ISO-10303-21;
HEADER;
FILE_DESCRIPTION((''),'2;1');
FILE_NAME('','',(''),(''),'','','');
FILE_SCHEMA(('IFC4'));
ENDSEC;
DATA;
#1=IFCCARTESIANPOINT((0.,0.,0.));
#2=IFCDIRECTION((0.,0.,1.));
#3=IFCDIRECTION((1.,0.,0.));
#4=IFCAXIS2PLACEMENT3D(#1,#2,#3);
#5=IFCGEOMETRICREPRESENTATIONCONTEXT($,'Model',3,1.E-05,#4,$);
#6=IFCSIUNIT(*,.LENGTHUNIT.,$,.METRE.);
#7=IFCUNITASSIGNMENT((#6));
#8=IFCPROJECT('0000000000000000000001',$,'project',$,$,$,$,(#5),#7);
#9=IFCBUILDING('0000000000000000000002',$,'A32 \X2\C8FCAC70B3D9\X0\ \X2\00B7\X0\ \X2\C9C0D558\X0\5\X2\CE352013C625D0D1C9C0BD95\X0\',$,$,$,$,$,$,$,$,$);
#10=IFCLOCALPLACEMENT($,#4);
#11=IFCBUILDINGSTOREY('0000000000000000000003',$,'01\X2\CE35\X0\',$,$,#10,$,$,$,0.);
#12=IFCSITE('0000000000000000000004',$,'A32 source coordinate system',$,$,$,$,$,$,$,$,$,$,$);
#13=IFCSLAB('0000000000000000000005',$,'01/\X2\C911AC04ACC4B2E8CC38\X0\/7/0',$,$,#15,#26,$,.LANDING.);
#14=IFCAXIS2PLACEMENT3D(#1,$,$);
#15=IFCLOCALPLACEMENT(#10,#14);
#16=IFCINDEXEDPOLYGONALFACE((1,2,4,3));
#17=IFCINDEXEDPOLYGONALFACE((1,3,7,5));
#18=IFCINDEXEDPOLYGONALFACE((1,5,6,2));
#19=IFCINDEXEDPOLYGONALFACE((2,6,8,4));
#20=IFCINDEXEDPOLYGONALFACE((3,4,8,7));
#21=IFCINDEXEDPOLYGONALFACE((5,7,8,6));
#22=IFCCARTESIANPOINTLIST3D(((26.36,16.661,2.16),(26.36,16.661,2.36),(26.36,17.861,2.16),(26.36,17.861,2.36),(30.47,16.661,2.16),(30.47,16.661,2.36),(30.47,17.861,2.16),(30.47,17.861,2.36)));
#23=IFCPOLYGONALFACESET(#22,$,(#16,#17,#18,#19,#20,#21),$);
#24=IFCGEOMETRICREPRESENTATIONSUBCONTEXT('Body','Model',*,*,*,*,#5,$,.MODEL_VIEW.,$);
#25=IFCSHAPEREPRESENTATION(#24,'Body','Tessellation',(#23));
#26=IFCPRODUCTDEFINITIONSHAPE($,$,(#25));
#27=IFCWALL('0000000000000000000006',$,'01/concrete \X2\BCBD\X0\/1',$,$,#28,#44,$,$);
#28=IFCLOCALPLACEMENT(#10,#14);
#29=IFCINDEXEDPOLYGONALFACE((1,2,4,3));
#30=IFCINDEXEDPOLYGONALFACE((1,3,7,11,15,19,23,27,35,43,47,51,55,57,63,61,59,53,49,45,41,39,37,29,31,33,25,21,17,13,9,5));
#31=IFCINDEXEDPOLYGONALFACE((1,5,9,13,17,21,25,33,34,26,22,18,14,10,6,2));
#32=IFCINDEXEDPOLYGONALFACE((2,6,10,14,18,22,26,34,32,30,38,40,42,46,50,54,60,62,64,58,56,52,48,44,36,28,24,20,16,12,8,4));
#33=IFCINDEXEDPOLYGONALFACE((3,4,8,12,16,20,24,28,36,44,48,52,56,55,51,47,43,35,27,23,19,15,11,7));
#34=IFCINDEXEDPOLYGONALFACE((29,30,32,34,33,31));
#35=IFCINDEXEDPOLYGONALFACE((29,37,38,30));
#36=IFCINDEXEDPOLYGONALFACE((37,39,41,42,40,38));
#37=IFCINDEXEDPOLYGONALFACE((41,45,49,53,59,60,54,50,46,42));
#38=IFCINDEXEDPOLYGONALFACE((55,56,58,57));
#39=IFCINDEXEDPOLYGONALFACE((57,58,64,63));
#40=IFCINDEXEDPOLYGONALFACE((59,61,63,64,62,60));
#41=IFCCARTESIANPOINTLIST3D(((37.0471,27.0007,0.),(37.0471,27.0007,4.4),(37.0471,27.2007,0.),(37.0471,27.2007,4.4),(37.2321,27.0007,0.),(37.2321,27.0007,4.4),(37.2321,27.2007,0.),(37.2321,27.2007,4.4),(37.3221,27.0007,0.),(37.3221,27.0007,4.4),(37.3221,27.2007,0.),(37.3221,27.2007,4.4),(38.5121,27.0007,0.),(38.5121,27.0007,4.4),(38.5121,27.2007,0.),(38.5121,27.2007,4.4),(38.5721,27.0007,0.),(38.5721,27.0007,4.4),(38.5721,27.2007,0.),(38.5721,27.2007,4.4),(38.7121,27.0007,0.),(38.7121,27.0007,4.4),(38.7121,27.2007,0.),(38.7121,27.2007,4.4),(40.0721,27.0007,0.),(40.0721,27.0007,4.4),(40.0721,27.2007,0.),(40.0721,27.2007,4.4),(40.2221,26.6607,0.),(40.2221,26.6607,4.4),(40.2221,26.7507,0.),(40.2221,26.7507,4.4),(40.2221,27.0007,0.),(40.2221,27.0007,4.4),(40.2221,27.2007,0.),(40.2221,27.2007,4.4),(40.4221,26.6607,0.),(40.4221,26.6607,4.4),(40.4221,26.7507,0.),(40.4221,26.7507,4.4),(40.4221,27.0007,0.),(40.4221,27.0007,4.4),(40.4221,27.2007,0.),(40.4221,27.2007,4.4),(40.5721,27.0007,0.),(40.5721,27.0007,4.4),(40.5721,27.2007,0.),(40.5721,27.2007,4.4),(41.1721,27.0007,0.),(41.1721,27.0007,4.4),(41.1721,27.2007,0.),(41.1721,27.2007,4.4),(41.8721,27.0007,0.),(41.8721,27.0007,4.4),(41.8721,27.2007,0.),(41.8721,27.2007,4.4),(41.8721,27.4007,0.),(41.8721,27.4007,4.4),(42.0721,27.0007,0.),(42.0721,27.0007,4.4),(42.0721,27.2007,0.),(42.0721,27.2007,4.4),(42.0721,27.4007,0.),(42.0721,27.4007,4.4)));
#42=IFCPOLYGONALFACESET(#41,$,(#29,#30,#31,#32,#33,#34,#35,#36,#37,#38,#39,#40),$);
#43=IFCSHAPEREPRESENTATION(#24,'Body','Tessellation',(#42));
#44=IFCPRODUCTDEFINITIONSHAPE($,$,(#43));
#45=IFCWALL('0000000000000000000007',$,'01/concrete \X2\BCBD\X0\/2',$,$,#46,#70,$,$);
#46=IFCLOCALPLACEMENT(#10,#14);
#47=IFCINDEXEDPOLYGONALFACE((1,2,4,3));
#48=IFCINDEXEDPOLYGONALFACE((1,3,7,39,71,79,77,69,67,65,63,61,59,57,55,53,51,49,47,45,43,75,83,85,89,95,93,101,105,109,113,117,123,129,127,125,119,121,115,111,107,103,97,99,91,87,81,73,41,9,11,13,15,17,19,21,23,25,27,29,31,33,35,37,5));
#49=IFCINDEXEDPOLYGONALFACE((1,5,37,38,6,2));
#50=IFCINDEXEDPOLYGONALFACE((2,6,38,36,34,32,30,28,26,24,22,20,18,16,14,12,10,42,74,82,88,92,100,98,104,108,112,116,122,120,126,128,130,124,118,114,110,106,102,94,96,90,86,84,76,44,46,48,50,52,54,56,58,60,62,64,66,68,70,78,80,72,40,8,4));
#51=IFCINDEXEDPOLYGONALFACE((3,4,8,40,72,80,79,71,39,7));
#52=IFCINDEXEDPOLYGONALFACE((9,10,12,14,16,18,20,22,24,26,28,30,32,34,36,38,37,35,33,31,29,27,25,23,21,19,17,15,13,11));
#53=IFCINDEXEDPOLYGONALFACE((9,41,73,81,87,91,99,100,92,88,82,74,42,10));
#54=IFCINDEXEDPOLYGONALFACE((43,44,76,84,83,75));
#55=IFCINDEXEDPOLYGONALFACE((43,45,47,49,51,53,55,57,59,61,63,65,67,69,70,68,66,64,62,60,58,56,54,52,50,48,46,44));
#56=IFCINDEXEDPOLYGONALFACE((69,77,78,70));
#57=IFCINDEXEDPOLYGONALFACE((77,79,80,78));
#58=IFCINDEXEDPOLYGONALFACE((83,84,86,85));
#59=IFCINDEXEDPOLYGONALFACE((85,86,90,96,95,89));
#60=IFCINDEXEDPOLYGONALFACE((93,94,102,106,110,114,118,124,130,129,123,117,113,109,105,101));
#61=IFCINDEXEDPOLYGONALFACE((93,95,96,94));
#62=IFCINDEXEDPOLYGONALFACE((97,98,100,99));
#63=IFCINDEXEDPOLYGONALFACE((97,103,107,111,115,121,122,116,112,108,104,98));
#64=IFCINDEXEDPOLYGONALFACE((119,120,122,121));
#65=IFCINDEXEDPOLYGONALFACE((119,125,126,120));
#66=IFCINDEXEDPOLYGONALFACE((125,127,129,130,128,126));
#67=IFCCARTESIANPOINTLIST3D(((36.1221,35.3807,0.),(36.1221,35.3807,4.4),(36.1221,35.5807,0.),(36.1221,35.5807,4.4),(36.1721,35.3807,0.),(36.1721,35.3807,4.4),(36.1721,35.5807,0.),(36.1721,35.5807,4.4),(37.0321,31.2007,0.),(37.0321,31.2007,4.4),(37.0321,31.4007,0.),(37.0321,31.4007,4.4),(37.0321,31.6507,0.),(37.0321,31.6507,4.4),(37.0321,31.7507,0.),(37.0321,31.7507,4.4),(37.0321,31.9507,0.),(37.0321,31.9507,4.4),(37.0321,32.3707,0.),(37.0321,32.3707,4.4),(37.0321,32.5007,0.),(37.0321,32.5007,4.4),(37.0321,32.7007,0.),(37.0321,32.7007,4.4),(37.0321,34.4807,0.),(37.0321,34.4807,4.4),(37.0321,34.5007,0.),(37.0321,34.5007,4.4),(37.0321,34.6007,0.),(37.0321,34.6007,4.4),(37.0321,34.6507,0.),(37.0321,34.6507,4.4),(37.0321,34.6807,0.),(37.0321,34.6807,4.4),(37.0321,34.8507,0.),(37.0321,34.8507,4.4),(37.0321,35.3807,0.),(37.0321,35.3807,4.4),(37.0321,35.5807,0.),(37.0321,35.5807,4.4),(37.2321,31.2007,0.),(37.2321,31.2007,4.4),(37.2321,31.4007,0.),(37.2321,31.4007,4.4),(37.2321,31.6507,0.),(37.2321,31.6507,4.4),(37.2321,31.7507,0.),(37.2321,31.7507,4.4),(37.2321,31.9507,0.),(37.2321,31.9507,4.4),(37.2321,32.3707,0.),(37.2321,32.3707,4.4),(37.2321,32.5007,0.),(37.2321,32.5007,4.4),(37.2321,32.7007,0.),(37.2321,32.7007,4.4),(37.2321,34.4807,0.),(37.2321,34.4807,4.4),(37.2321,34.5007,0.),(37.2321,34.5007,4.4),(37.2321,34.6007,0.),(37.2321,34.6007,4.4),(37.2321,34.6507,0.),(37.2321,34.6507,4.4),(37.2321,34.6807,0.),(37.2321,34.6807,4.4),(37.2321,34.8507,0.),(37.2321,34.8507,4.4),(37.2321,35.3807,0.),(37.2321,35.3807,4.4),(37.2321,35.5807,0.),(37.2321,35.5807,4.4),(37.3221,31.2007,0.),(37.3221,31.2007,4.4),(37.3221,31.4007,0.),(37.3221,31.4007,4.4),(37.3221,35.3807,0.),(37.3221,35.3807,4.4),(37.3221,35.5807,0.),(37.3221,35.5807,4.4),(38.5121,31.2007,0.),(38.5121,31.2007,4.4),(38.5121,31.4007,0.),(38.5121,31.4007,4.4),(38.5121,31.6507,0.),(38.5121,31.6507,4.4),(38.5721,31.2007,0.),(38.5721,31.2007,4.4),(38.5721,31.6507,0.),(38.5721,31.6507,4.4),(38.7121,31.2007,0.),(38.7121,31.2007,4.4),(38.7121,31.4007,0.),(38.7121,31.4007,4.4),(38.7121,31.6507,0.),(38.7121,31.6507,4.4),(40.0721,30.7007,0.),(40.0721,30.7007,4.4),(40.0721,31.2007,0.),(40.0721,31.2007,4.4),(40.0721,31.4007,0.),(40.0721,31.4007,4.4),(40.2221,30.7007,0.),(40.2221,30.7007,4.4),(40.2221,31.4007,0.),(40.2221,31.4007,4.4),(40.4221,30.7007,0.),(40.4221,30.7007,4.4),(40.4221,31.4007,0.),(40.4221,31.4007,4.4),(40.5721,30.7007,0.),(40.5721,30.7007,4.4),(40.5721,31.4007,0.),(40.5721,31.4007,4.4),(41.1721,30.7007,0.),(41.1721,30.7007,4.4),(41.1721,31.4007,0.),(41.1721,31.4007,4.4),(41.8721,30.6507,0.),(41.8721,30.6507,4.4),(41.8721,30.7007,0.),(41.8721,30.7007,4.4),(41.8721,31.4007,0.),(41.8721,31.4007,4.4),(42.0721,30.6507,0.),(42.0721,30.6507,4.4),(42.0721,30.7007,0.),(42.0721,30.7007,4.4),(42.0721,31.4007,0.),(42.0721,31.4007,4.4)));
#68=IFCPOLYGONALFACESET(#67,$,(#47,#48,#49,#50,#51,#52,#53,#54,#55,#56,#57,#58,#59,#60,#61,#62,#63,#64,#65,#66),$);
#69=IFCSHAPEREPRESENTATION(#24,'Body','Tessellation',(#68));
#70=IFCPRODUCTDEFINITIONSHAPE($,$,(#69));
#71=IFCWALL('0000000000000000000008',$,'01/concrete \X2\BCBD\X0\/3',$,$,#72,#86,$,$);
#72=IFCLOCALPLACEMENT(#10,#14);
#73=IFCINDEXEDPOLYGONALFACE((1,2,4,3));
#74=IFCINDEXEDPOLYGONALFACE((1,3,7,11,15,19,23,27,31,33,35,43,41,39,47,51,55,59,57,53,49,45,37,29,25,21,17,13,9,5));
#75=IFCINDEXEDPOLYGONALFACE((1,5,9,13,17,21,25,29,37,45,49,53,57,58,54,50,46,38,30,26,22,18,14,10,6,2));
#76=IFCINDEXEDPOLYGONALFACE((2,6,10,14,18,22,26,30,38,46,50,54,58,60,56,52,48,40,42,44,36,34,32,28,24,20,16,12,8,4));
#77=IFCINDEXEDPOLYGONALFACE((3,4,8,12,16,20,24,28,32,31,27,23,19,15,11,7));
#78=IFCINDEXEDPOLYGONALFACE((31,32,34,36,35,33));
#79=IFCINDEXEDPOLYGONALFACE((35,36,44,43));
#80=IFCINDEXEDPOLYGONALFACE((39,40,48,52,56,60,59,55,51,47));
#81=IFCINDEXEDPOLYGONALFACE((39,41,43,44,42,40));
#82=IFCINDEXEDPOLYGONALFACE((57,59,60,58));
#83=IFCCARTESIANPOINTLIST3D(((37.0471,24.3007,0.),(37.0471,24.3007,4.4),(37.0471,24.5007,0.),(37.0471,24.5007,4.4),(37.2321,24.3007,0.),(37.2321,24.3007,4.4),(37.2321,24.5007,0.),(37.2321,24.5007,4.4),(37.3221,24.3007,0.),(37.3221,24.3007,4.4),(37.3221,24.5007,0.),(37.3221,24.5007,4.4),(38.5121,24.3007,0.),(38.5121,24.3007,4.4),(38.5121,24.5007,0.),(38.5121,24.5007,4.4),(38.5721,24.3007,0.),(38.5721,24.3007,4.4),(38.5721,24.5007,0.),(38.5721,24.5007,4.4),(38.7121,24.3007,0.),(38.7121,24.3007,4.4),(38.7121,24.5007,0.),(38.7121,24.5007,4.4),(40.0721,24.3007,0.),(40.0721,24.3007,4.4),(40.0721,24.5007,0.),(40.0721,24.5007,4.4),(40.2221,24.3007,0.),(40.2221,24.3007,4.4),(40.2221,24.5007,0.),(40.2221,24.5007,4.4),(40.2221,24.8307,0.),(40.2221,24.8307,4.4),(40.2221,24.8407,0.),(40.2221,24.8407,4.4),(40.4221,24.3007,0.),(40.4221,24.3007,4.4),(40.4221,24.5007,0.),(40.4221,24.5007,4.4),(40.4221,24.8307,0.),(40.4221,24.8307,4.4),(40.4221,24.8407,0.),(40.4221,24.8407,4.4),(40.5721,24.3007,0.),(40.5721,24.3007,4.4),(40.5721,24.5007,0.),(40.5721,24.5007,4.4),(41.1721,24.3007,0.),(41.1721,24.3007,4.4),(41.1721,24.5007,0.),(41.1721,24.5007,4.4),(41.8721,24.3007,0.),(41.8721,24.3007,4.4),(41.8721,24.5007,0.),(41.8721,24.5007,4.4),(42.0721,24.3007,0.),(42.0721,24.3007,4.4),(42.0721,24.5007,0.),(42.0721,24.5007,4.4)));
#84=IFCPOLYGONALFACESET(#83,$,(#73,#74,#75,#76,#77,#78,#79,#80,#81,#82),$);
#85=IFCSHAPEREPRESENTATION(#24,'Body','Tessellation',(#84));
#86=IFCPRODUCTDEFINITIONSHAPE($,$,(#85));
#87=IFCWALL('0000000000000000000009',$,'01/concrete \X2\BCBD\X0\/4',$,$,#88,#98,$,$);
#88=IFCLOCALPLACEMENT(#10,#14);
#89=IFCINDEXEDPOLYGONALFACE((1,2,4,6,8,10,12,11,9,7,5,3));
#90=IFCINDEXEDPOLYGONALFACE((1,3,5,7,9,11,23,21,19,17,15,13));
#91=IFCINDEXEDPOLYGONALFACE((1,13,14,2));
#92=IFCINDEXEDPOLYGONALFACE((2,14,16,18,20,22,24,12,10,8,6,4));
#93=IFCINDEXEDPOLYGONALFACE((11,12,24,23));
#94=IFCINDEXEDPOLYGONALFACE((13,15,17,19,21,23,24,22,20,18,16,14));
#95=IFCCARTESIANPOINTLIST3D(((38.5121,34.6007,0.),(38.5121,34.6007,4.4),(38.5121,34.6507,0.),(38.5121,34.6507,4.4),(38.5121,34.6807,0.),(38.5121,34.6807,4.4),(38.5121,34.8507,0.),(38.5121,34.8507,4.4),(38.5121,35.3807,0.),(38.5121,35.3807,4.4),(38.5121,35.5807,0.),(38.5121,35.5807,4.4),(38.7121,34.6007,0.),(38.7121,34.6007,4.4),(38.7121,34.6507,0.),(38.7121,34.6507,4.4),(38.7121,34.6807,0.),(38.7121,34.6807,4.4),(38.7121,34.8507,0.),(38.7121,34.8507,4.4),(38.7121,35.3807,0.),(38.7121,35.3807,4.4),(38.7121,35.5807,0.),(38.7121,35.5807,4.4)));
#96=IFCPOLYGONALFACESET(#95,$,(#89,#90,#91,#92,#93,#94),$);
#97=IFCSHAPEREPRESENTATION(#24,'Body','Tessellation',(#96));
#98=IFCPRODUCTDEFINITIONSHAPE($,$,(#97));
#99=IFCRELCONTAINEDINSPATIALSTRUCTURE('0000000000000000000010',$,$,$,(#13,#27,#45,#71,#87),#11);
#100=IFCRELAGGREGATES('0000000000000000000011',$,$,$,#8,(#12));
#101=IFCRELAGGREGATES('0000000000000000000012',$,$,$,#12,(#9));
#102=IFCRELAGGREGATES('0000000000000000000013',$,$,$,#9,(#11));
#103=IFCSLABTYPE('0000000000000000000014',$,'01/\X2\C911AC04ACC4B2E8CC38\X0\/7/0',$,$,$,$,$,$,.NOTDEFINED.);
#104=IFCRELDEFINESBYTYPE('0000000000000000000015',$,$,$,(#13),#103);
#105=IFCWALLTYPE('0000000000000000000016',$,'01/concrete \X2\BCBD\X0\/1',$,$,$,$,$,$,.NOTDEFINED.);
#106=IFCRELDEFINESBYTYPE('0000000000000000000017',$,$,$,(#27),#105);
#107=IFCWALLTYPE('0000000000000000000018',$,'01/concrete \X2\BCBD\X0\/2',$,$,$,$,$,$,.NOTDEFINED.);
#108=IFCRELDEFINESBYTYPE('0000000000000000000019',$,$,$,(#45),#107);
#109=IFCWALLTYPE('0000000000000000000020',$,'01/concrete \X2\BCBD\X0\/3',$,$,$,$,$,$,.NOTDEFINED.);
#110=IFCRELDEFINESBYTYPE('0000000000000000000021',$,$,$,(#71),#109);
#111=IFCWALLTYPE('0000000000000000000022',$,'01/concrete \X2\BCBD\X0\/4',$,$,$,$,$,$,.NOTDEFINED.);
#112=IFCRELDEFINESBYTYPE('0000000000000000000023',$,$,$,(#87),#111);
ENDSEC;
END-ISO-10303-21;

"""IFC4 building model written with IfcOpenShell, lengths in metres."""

from ifc_helpers import new_model, si_unit, frame, origin, origin_with_axes, place, context, subcontext, project, spatial, polyline, outline, extrude, source, transform, mapped, type_object, type_shapes, element, save


model = new_model("IFC4")

# Units and contexts
model_context = context("Model", 3, precision=1e-05, world=origin_with_axes())
body_context = subcontext(model_context, "Body", "Model", "MODEL_VIEW")
ifc_project = project(units=[si_unit("LENGTHUNIT", "METRE")], contexts=[model_context])

# Site, building, storey
storey_placement = place(None, origin_with_axes())
site = spatial("IfcSite", under=ifc_project, Name="A32 source coordinate system")
building = spatial("IfcBuilding", under=site, Name="A32 주거동 · 지하5층–옥탑지붕")
storey = spatial("IfcBuildingStorey", under=building, at=storey_placement, Name="01층", Elevation=0.0)

# Slab
slab_type_1 = type_object("IfcSlabType", Name="01/중간계단참/7/0", PredefinedType="NOTDEFINED")
shared_shape_1 = source(origin(), body_context, "Body", "SweptSolid", [
    extrude(outline(polyline([(30.47, 16.661), (26.36, 16.661), (26.36, 17.861), (30.47, 17.861), (30.47, 16.661)])), frame((0.0, 0.0, 2.16)), (0.0, 0.0, 1.0), 0.2),
])
type_shapes(slab_type_1, [shared_shape_1])
slab_1_placement = place(storey_placement, origin_with_axes())
element("IfcSlab", 1, at=slab_1_placement, inside=storey, type_object=slab_type_1, Name="01/중간계단참/7/0", PredefinedType="LANDING", context=body_context, shape_type="MappedRepresentation", body=[
    mapped(shared_shape_1, transform((0.0, 0.0, 0.0), scale=1.0)),
])

# Walls
wall_type_1 = type_object("IfcWallType", Name="01/concrete 벽/1", PredefinedType="NOTDEFINED")
shared_shape_2 = source(origin(), body_context, "Body", "SweptSolid", [
    extrude(outline(polyline([(37.3221, 27.2007), (38.5121, 27.2007), (38.5721, 27.2007), (38.7121, 27.2007), (40.0721, 27.2007), (40.2221, 27.2007), (40.4221, 27.2007), (40.5721, 27.2007), (41.1721, 27.2007), (41.8721, 27.2007), (41.8721, 27.4007), (42.0721, 27.4007), (42.0721, 27.2007), (42.0721, 27.0007), (41.8721, 27.0007), (41.1721, 27.0007), (40.5721, 27.0007), (40.4221, 27.0007), (40.4221, 26.7507), (40.4221, 26.6607), (40.2221, 26.6607), (40.2221, 26.7507), (40.2221, 27.0007), (40.0721, 27.0007), (38.7121, 27.0007), (38.5721, 27.0007), (38.5121, 27.0007), (37.3221, 27.0007), (37.2321, 27.0007), (37.0471, 27.0007), (37.0471, 27.2007), (37.2321, 27.2007), (37.3221, 27.2007)])), origin(), (0.0, 0.0, 1.0), 4.4),
])
type_shapes(wall_type_1, [shared_shape_2])
wall_1_placement = place(storey_placement, origin_with_axes())
element("IfcWall", 2, at=wall_1_placement, inside=storey, type_object=wall_type_1, Name="01/concrete 벽/1", context=body_context, shape_type="MappedRepresentation", body=[
    mapped(shared_shape_2, transform((0.0, 0.0, 0.0), scale=1.0)),
])
wall_type_2 = type_object("IfcWallType", Name="01/concrete 벽/2", PredefinedType="NOTDEFINED")
shared_shape_3 = source(origin(), body_context, "Body", "SweptSolid", [
    extrude(outline(polyline([(38.7121, 31.4007), (40.0721, 31.4007), (40.2221, 31.4007), (40.4221, 31.4007), (40.5721, 31.4007), (41.1721, 31.4007), (41.8721, 31.4007), (42.0721, 31.4007), (42.0721, 30.7007), (42.0721, 30.6507), (41.8721, 30.6507), (41.8721, 30.7007), (41.1721, 30.7007), (40.5721, 30.7007), (40.4221, 30.7007), (40.2221, 30.7007), (40.0721, 30.7007), (40.0721, 31.2007), (38.7121, 31.2007), (38.5721, 31.2007), (38.5121, 31.2007), (37.3221, 31.2007), (37.2321, 31.2007), (37.0321, 31.2007), (37.0321, 31.4007), (37.0321, 31.6507), (37.0321, 31.7507), (37.0321, 31.9507), (37.0321, 32.3707), (37.0321, 32.5007), (37.0321, 32.7007), (37.0321, 34.4807), (37.0321, 34.5007), (37.0321, 34.6007), (37.0321, 34.6507), (37.0321, 34.6807), (37.0321, 34.8507), (37.0321, 35.3807), (36.1721, 35.3807), (36.1221, 35.3807), (36.1221, 35.5807), (36.1721, 35.5807), (37.0321, 35.5807), (37.2321, 35.5807), (37.3221, 35.5807), (37.3221, 35.3807), (37.2321, 35.3807), (37.2321, 34.8507), (37.2321, 34.6807), (37.2321, 34.6507), (37.2321, 34.6007), (37.2321, 34.5007), (37.2321, 34.4807), (37.2321, 32.7007), (37.2321, 32.5007), (37.2321, 32.3707), (37.2321, 31.9507), (37.2321, 31.7507), (37.2321, 31.6507), (37.2321, 31.4007), (37.3221, 31.4007), (38.5121, 31.4007), (38.5121, 31.6507), (38.5721, 31.6507), (38.7121, 31.6507), (38.7121, 31.4007)])), origin(), (0.0, 0.0, 1.0), 4.4),
])
type_shapes(wall_type_2, [shared_shape_3])
wall_2_placement = place(storey_placement, origin_with_axes())
element("IfcWall", 3, at=wall_2_placement, inside=storey, type_object=wall_type_2, Name="01/concrete 벽/2", context=body_context, shape_type="MappedRepresentation", body=[
    mapped(shared_shape_3, transform((0.0, 0.0, 0.0), scale=1.0)),
])
wall_type_3 = type_object("IfcWallType", Name="01/concrete 벽/3", PredefinedType="NOTDEFINED")
shared_shape_4 = source(origin(), body_context, "Body", "SweptSolid", [
    extrude(outline(polyline([(38.5721, 24.3007), (38.5121, 24.3007), (37.3221, 24.3007), (37.2321, 24.3007), (37.0471, 24.3007), (37.0471, 24.5007), (37.2321, 24.5007), (37.3221, 24.5007), (38.5121, 24.5007), (38.5721, 24.5007), (38.7121, 24.5007), (40.0721, 24.5007), (40.2221, 24.5007), (40.2221, 24.8307), (40.2221, 24.8407), (40.4221, 24.8407), (40.4221, 24.8307), (40.4221, 24.5007), (40.5721, 24.5007), (41.1721, 24.5007), (41.8721, 24.5007), (42.0721, 24.5007), (42.0721, 24.3007), (41.8721, 24.3007), (41.1721, 24.3007), (40.5721, 24.3007), (40.4221, 24.3007), (40.2221, 24.3007), (40.0721, 24.3007), (38.7121, 24.3007), (38.5721, 24.3007)])), origin(), (0.0, 0.0, 1.0), 4.4),
])
type_shapes(wall_type_3, [shared_shape_4])
wall_3_placement = place(storey_placement, origin_with_axes())
element("IfcWall", 4, at=wall_3_placement, inside=storey, type_object=wall_type_3, Name="01/concrete 벽/3", context=body_context, shape_type="MappedRepresentation", body=[
    mapped(shared_shape_4, transform((0.0, 0.0, 0.0), scale=1.0)),
])
wall_type_4 = type_object("IfcWallType", Name="01/concrete 벽/4", PredefinedType="NOTDEFINED")
shared_shape_5 = source(origin(), body_context, "Body", "SweptSolid", [
    extrude(outline(polyline([(38.7121, 34.8507), (38.7121, 34.6807), (38.7121, 34.6507), (38.7121, 34.6007), (38.5121, 34.6007), (38.5121, 34.6507), (38.5121, 34.6807), (38.5121, 34.8507), (38.5121, 35.3807), (38.5121, 35.5807), (38.7121, 35.5807), (38.7121, 35.3807), (38.7121, 34.8507)])), origin(), (0.0, 0.0, 1.0), 4.4),
])
type_shapes(wall_type_4, [shared_shape_5])
wall_4_placement = place(storey_placement, origin_with_axes())
element("IfcWall", 5, at=wall_4_placement, inside=storey, type_object=wall_type_4, Name="01/concrete 벽/4", context=body_context, shape_type="MappedRepresentation", body=[
    mapped(shared_shape_5, transform((0.0, 0.0, 0.0), scale=1.0)),
])

save(model, "model.ifc")
